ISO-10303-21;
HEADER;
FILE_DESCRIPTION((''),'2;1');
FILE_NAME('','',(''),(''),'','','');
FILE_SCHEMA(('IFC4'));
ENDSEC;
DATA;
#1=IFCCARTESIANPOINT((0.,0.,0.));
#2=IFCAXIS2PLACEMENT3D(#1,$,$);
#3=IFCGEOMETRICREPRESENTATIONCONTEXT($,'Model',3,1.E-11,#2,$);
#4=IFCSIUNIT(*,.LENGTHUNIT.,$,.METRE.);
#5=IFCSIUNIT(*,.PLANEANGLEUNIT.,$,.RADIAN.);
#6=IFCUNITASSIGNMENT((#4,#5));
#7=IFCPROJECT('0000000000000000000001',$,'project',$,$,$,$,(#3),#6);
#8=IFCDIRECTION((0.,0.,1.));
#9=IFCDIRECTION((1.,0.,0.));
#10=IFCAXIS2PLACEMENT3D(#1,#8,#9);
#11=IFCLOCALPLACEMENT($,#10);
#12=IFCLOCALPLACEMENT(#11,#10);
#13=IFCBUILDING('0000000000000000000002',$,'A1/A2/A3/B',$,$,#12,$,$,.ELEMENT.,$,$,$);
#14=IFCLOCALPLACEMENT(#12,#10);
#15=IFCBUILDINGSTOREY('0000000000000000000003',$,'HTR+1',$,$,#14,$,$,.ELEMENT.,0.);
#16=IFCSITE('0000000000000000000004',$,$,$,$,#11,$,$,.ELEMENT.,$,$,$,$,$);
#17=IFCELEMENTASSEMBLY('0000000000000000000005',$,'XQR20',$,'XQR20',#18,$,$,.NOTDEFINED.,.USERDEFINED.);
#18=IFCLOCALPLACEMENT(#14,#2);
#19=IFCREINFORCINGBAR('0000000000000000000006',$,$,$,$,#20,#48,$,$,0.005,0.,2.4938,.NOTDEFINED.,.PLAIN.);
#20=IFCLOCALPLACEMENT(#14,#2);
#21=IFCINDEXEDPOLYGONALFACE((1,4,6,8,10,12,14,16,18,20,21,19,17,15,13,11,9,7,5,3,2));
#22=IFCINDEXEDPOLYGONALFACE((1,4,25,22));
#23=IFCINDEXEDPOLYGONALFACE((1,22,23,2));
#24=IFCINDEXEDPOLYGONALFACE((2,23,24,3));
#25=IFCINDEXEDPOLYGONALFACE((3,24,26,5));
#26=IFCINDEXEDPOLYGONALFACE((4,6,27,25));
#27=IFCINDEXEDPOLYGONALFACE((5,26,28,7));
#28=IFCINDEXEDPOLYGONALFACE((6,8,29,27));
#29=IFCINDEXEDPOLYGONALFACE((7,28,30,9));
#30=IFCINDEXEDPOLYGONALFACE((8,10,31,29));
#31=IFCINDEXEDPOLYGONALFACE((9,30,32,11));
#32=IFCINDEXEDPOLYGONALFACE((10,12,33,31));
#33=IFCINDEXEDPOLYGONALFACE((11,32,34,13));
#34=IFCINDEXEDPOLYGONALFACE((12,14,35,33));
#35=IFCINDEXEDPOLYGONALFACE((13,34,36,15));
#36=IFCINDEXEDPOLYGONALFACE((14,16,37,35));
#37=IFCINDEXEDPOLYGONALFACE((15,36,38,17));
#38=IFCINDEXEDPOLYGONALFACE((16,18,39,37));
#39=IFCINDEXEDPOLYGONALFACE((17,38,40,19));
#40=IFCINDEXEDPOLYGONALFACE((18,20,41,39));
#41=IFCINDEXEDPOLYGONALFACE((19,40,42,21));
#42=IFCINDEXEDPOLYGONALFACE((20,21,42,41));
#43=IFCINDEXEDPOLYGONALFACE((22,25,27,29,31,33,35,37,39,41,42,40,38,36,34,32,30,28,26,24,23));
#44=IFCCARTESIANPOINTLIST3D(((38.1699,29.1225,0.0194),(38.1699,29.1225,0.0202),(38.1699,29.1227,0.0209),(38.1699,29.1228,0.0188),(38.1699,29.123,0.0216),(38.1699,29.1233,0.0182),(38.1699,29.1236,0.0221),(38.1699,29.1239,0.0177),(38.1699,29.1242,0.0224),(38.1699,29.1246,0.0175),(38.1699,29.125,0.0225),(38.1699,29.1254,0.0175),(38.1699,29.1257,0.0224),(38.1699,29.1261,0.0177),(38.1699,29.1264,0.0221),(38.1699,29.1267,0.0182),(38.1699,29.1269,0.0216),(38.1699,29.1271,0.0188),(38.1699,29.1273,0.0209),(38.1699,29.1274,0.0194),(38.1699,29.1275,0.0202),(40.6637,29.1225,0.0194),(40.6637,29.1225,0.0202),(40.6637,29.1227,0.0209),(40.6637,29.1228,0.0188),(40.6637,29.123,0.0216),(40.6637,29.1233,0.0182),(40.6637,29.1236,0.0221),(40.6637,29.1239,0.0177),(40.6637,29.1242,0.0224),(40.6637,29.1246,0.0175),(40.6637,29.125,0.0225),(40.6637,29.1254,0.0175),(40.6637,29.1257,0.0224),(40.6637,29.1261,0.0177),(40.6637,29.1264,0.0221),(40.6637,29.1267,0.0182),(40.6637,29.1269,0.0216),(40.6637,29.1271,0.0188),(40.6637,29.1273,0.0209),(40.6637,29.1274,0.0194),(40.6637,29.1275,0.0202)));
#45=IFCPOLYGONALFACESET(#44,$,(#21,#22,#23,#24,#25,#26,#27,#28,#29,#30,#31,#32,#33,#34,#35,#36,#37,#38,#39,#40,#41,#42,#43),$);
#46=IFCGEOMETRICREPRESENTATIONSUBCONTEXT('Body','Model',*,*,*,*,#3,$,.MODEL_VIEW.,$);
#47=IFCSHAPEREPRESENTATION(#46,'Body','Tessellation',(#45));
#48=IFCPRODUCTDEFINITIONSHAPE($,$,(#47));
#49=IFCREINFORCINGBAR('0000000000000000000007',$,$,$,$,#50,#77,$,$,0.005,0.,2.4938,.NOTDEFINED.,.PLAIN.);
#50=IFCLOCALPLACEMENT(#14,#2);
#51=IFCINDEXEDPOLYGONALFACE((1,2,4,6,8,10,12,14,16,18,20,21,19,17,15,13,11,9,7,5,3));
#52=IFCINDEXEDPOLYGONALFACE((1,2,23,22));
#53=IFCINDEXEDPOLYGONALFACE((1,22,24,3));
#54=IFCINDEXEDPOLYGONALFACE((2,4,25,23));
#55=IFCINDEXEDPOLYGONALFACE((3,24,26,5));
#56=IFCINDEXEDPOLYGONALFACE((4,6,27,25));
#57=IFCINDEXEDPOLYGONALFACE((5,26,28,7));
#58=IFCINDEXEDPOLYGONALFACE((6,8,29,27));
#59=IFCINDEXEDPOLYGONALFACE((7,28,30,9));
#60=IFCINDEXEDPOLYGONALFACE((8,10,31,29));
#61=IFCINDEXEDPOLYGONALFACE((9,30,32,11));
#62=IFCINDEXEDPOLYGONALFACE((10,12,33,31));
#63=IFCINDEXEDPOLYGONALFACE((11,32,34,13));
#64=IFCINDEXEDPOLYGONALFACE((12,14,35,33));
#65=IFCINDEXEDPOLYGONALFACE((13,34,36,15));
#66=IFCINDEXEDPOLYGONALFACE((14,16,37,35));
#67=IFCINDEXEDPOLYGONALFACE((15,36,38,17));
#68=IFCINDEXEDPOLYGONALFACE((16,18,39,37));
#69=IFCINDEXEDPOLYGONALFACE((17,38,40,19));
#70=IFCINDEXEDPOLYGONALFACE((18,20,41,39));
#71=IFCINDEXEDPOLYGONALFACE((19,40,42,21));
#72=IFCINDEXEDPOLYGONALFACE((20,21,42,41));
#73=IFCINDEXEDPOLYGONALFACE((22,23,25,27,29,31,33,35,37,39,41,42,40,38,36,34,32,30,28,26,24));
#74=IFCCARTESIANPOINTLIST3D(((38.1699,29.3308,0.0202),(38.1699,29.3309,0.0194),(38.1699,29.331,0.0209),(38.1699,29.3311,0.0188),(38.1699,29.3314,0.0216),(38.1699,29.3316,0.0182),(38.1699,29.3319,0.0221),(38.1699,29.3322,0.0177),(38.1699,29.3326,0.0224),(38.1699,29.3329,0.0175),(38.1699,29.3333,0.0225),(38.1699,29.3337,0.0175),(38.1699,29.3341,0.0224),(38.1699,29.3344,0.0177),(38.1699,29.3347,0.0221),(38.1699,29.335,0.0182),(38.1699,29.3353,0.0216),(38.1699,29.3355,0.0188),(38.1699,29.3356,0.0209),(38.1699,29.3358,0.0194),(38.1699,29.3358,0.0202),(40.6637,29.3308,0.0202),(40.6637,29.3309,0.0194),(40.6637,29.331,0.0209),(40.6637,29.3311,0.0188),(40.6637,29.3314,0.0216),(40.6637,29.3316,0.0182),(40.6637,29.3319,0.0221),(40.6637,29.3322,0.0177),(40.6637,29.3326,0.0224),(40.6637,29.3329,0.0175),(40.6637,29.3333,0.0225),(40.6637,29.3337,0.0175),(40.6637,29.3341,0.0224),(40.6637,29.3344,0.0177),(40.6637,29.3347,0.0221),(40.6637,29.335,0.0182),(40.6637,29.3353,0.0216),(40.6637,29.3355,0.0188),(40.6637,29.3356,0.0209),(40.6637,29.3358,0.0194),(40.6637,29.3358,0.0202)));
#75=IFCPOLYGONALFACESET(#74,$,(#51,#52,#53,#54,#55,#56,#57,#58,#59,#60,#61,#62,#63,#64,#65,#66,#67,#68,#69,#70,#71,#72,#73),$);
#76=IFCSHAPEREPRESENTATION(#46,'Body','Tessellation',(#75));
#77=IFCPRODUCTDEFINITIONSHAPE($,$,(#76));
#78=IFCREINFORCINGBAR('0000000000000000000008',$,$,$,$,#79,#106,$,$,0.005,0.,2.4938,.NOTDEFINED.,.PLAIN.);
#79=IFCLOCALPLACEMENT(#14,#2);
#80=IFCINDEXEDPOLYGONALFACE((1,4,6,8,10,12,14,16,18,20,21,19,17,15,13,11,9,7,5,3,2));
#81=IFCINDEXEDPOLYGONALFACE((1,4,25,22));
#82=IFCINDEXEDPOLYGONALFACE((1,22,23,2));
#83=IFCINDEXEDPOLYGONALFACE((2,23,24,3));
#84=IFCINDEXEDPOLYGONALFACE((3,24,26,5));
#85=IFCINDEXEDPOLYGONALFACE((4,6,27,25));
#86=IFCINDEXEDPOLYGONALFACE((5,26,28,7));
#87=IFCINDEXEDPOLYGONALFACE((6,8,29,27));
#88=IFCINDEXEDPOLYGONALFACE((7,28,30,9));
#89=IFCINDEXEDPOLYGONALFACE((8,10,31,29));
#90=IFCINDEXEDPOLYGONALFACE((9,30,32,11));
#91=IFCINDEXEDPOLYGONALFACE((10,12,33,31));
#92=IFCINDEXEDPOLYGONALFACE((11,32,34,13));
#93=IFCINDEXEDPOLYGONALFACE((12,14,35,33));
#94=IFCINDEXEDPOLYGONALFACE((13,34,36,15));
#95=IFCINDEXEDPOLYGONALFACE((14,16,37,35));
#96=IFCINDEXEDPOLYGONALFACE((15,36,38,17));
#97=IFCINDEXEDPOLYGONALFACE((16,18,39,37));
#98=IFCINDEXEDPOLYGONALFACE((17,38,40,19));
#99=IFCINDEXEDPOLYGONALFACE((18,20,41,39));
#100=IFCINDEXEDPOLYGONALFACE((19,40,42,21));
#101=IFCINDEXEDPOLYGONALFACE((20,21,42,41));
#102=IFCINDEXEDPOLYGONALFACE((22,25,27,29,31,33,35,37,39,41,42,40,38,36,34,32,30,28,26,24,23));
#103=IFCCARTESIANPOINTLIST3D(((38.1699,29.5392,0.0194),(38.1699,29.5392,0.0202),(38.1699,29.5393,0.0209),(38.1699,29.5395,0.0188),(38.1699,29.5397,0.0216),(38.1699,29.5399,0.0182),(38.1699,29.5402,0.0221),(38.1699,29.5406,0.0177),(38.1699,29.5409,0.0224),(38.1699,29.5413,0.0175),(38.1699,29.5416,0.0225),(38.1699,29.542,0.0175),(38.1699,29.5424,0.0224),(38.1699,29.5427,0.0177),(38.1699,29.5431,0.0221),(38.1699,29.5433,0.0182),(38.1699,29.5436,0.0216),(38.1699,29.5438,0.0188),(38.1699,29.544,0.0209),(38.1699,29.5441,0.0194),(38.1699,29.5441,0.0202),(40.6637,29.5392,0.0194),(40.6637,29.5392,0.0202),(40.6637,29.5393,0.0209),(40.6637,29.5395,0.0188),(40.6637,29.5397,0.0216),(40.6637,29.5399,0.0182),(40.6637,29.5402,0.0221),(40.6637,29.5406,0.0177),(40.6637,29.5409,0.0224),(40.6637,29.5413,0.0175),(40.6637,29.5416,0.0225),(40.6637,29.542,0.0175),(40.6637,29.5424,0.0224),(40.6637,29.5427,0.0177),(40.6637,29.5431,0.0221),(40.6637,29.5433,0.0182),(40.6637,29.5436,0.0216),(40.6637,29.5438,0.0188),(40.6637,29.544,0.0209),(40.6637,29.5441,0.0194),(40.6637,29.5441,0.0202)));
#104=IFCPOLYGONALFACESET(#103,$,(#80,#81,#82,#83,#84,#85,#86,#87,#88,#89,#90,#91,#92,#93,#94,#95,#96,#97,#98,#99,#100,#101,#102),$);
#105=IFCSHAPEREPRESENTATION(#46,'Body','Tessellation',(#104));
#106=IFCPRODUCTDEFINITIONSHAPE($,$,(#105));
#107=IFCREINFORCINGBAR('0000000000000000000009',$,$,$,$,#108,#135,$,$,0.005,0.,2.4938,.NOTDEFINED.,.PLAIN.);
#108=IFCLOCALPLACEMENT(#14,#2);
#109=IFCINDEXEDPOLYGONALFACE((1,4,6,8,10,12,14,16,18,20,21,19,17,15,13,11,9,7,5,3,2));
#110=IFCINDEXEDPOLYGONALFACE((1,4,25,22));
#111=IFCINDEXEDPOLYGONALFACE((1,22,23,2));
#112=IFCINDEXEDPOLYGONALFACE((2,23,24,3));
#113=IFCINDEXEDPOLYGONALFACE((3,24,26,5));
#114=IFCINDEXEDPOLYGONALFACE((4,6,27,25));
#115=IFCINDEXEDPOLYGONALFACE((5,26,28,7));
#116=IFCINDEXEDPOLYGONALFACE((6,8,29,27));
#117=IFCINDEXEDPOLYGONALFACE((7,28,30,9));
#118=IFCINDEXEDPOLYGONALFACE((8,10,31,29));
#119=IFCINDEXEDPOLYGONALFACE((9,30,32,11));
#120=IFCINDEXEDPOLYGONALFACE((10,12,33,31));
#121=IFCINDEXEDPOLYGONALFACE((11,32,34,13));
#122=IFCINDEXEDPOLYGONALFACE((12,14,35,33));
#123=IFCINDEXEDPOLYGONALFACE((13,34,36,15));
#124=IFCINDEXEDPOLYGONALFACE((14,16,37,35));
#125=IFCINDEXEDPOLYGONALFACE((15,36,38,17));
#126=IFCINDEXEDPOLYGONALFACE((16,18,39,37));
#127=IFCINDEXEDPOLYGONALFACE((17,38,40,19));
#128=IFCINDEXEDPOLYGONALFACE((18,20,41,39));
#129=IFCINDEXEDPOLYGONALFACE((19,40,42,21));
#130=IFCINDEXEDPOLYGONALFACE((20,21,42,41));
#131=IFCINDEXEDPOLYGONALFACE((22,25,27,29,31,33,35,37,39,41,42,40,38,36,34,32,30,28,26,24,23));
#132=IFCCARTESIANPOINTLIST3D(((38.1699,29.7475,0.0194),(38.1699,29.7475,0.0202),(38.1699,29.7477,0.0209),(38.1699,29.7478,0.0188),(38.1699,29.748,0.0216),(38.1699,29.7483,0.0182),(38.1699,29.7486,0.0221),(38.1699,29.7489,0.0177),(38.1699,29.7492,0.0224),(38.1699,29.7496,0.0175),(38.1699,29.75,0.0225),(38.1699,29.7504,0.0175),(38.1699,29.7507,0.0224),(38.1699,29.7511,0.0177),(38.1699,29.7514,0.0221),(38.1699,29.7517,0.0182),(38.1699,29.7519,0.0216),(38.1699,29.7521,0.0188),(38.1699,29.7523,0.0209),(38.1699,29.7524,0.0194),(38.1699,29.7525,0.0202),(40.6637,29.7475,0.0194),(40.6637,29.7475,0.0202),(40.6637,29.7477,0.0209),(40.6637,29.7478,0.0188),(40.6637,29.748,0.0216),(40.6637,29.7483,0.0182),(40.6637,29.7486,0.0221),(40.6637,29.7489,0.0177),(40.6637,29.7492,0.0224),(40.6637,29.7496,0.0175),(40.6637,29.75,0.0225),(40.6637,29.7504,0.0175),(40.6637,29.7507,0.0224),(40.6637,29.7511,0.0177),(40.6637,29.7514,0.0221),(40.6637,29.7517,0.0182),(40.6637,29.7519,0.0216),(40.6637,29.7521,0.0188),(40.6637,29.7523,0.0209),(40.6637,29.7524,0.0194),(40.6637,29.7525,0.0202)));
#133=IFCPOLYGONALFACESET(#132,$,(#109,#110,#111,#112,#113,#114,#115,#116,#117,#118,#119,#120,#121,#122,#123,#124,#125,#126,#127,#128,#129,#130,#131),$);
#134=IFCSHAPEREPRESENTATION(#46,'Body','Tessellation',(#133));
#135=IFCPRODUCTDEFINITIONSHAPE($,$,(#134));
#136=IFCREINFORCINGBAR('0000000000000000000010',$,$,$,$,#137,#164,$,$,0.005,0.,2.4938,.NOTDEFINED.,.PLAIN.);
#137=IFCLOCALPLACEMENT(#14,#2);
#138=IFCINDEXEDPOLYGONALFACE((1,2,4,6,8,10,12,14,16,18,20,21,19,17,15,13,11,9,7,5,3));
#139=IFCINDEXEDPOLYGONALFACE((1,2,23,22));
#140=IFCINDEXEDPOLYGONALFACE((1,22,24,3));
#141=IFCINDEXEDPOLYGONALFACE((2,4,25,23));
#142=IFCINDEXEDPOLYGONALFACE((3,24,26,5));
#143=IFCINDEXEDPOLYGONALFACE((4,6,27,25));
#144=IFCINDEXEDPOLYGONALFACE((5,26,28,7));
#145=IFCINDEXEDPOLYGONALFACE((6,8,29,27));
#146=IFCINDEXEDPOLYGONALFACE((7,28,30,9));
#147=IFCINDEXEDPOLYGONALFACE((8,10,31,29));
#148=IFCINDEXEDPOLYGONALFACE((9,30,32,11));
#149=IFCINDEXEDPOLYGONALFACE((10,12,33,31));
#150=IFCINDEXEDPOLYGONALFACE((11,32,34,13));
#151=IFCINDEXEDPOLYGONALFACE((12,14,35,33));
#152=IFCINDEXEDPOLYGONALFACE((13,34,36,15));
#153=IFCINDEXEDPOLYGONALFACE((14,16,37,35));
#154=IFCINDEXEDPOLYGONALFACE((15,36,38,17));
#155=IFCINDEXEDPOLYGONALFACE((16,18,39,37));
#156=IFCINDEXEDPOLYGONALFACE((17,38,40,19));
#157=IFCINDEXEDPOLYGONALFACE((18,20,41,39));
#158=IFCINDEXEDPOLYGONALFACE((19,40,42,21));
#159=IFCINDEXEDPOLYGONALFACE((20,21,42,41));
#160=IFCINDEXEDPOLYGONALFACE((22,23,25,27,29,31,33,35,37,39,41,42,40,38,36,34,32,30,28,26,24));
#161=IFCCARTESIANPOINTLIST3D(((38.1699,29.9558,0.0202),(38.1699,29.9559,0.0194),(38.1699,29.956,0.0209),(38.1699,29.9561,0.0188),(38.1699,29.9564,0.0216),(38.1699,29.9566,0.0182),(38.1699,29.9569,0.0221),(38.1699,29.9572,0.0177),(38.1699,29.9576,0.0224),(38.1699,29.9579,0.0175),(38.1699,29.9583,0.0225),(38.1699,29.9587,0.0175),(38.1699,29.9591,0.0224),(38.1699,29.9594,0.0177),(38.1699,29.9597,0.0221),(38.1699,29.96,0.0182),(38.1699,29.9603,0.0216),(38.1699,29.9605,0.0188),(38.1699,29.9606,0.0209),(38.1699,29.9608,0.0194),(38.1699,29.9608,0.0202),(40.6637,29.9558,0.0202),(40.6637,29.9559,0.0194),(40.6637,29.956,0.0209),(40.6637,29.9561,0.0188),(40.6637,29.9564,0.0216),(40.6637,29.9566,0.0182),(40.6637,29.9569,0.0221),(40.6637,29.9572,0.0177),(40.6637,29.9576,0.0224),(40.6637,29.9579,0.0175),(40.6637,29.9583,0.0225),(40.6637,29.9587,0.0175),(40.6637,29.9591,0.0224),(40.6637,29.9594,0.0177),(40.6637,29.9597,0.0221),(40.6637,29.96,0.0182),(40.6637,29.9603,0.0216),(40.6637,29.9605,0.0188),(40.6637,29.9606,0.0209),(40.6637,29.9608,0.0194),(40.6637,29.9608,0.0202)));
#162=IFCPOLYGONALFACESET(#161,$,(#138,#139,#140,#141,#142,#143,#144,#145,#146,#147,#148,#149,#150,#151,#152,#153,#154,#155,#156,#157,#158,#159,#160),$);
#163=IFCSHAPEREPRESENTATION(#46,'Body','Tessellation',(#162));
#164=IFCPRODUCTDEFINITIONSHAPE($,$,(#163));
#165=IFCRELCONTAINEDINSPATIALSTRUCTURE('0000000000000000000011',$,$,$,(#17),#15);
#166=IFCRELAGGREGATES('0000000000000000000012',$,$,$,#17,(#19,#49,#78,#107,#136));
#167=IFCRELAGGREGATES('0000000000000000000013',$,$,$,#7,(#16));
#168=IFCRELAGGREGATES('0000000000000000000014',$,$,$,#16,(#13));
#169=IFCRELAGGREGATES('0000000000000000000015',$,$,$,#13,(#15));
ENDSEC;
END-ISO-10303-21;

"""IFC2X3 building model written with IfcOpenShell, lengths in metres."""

from ifc_helpers import new_model, entity, si_unit, origin, origin_with_axes, place, context, subcontext, project, spatial, shape, element, aggregate, save


model = new_model("IFC2X3")

# Units and contexts
model_context = context("Model", 3, precision=1e-11, world=origin())
body_context = subcontext(model_context, "Body", "Model", "MODEL_VIEW")
ifc_project = project(units=[si_unit("LENGTHUNIT", "METRE"), si_unit("PLANEANGLEUNIT", "RADIAN")], contexts=[model_context])

# Site, building, storey
site_placement = place(None, origin_with_axes())
site = spatial("IfcSite", under=ifc_project, at=site_placement, CompositionType="ELEMENT")
building_placement = place(site_placement, origin_with_axes())
building = spatial("IfcBuilding", under=site, at=building_placement, Name="A1/A2/A3/B", CompositionType="ELEMENT")
storey_placement = place(building_placement, origin_with_axes())
storey = spatial("IfcBuildingStorey", under=building, at=storey_placement, Name="HTR+1", CompositionType="ELEMENT", Elevation=0.0)

# Element assembly, reinforcing bars
assembly_1_placement = place(storey_placement, origin_with_axes())
assembly_1 = element("IfcElementAssembly", 1, at=assembly_1_placement, inside=storey, Name="XQR20", ObjectType="XQR20", AssemblyPlace="NOTDEFINED", PredefinedType="USERDEFINED")
reinforcing_bar_1_placement = place(assembly_1_placement, origin_with_axes())
reinforcing_bar_1 = element("IfcReinforcingBar", 2, at=reinforcing_bar_1_placement, BarLength=2.4938, BarRole="NOTDEFINED", BarSurface="PLAIN", CrossSectionArea=0.0, NominalDiameter=0.005, shapes=[
    shape(body_context, "Body", "AdvancedSweptSolid", [entity("IfcSweptDiskSolid", entity("IfcPolyline", [entity("IfcCartesianPoint", [38.1699, 29.125, 0.02]), entity("IfcCartesianPoint", [40.6637, 29.125, 0.02])]), 0.0025, None, 0.0, 2.4938)]),
    shape(body_context, "Body", "AdvancedSweptSolid", [entity("IfcSweptDiskSolid", entity("IfcPolyline", [entity("IfcCartesianPoint", [38.1699, 29.125, 0.02]), entity("IfcCartesianPoint", [40.6637, 29.125, 0.02])]), 0.0025, None, 0.0, 2.4938)]),
])
reinforcing_bar_2_placement = place(assembly_1_placement, origin_with_axes())
reinforcing_bar_2 = element("IfcReinforcingBar", 3, at=reinforcing_bar_2_placement, BarLength=2.4938, BarRole="NOTDEFINED", BarSurface="PLAIN", CrossSectionArea=0.0, NominalDiameter=0.005, shapes=[
    shape(body_context, "Body", "AdvancedSweptSolid", [entity("IfcSweptDiskSolid", entity("IfcPolyline", [entity("IfcCartesianPoint", [38.1699, 29.3333, 0.02]), entity("IfcCartesianPoint", [40.6637, 29.3333, 0.02])]), 0.0025, None, 0.0, 2.4938)]),
    shape(body_context, "Body", "AdvancedSweptSolid", [entity("IfcSweptDiskSolid", entity("IfcPolyline", [entity("IfcCartesianPoint", [38.1699, 29.3333, 0.02]), entity("IfcCartesianPoint", [40.6637, 29.3333, 0.02])]), 0.0025, None, 0.0, 2.4938)]),
])
reinforcing_bar_3_placement = place(assembly_1_placement, origin_with_axes())
reinforcing_bar_3 = element("IfcReinforcingBar", 4, at=reinforcing_bar_3_placement, BarLength=2.4938, BarRole="NOTDEFINED", BarSurface="PLAIN", CrossSectionArea=0.0, NominalDiameter=0.005, shapes=[
    shape(body_context, "Body", "AdvancedSweptSolid", [entity("IfcSweptDiskSolid", entity("IfcPolyline", [entity("IfcCartesianPoint", [38.1699, 29.5416, 0.02]), entity("IfcCartesianPoint", [40.6637, 29.5416, 0.02])]), 0.0025, None, 0.0, 2.4938)]),
    shape(body_context, "Body", "AdvancedSweptSolid", [entity("IfcSweptDiskSolid", entity("IfcPolyline", [entity("IfcCartesianPoint", [38.1699, 29.5416, 0.02]), entity("IfcCartesianPoint", [40.6637, 29.5416, 0.02])]), 0.0025, None, 0.0, 2.4938)]),
])
reinforcing_bar_4_placement = place(assembly_1_placement, origin_with_axes())
reinforcing_bar_4 = element("IfcReinforcingBar", 5, at=reinforcing_bar_4_placement, BarLength=2.4938, BarRole="NOTDEFINED", BarSurface="PLAIN", CrossSectionArea=0.0, NominalDiameter=0.005, shapes=[
    shape(body_context, "Body", "AdvancedSweptSolid", [entity("IfcSweptDiskSolid", entity("IfcPolyline", [entity("IfcCartesianPoint", [38.1699, 29.75, 0.02]), entity("IfcCartesianPoint", [40.6637, 29.75, 0.02])]), 0.0025, None, 0.0, 2.4938)]),
    shape(body_context, "Body", "AdvancedSweptSolid", [entity("IfcSweptDiskSolid", entity("IfcPolyline", [entity("IfcCartesianPoint", [38.1699, 29.75, 0.02]), entity("IfcCartesianPoint", [40.6637, 29.75, 0.02])]), 0.0025, None, 0.0, 2.4938)]),
])
reinforcing_bar_5_placement = place(assembly_1_placement, origin_with_axes())
reinforcing_bar_5 = element("IfcReinforcingBar", 6, at=reinforcing_bar_5_placement, BarLength=2.4938, BarRole="NOTDEFINED", BarSurface="PLAIN", CrossSectionArea=0.0, NominalDiameter=0.005, shapes=[
    shape(body_context, "Body", "AdvancedSweptSolid", [entity("IfcSweptDiskSolid", entity("IfcPolyline", [entity("IfcCartesianPoint", [38.1699, 29.9583, 0.02]), entity("IfcCartesianPoint", [40.6637, 29.9583, 0.02])]), 0.0025, None, 0.0, 2.4938)]),
    shape(body_context, "Body", "AdvancedSweptSolid", [entity("IfcSweptDiskSolid", entity("IfcPolyline", [entity("IfcCartesianPoint", [38.1699, 29.9583, 0.02]), entity("IfcCartesianPoint", [40.6637, 29.9583, 0.02])]), 0.0025, None, 0.0, 2.4938)]),
])
aggregate(assembly_1, [reinforcing_bar_1, reinforcing_bar_2, reinforcing_bar_3, reinforcing_bar_4, reinforcing_bar_5])

save(model, "model.ifc")
